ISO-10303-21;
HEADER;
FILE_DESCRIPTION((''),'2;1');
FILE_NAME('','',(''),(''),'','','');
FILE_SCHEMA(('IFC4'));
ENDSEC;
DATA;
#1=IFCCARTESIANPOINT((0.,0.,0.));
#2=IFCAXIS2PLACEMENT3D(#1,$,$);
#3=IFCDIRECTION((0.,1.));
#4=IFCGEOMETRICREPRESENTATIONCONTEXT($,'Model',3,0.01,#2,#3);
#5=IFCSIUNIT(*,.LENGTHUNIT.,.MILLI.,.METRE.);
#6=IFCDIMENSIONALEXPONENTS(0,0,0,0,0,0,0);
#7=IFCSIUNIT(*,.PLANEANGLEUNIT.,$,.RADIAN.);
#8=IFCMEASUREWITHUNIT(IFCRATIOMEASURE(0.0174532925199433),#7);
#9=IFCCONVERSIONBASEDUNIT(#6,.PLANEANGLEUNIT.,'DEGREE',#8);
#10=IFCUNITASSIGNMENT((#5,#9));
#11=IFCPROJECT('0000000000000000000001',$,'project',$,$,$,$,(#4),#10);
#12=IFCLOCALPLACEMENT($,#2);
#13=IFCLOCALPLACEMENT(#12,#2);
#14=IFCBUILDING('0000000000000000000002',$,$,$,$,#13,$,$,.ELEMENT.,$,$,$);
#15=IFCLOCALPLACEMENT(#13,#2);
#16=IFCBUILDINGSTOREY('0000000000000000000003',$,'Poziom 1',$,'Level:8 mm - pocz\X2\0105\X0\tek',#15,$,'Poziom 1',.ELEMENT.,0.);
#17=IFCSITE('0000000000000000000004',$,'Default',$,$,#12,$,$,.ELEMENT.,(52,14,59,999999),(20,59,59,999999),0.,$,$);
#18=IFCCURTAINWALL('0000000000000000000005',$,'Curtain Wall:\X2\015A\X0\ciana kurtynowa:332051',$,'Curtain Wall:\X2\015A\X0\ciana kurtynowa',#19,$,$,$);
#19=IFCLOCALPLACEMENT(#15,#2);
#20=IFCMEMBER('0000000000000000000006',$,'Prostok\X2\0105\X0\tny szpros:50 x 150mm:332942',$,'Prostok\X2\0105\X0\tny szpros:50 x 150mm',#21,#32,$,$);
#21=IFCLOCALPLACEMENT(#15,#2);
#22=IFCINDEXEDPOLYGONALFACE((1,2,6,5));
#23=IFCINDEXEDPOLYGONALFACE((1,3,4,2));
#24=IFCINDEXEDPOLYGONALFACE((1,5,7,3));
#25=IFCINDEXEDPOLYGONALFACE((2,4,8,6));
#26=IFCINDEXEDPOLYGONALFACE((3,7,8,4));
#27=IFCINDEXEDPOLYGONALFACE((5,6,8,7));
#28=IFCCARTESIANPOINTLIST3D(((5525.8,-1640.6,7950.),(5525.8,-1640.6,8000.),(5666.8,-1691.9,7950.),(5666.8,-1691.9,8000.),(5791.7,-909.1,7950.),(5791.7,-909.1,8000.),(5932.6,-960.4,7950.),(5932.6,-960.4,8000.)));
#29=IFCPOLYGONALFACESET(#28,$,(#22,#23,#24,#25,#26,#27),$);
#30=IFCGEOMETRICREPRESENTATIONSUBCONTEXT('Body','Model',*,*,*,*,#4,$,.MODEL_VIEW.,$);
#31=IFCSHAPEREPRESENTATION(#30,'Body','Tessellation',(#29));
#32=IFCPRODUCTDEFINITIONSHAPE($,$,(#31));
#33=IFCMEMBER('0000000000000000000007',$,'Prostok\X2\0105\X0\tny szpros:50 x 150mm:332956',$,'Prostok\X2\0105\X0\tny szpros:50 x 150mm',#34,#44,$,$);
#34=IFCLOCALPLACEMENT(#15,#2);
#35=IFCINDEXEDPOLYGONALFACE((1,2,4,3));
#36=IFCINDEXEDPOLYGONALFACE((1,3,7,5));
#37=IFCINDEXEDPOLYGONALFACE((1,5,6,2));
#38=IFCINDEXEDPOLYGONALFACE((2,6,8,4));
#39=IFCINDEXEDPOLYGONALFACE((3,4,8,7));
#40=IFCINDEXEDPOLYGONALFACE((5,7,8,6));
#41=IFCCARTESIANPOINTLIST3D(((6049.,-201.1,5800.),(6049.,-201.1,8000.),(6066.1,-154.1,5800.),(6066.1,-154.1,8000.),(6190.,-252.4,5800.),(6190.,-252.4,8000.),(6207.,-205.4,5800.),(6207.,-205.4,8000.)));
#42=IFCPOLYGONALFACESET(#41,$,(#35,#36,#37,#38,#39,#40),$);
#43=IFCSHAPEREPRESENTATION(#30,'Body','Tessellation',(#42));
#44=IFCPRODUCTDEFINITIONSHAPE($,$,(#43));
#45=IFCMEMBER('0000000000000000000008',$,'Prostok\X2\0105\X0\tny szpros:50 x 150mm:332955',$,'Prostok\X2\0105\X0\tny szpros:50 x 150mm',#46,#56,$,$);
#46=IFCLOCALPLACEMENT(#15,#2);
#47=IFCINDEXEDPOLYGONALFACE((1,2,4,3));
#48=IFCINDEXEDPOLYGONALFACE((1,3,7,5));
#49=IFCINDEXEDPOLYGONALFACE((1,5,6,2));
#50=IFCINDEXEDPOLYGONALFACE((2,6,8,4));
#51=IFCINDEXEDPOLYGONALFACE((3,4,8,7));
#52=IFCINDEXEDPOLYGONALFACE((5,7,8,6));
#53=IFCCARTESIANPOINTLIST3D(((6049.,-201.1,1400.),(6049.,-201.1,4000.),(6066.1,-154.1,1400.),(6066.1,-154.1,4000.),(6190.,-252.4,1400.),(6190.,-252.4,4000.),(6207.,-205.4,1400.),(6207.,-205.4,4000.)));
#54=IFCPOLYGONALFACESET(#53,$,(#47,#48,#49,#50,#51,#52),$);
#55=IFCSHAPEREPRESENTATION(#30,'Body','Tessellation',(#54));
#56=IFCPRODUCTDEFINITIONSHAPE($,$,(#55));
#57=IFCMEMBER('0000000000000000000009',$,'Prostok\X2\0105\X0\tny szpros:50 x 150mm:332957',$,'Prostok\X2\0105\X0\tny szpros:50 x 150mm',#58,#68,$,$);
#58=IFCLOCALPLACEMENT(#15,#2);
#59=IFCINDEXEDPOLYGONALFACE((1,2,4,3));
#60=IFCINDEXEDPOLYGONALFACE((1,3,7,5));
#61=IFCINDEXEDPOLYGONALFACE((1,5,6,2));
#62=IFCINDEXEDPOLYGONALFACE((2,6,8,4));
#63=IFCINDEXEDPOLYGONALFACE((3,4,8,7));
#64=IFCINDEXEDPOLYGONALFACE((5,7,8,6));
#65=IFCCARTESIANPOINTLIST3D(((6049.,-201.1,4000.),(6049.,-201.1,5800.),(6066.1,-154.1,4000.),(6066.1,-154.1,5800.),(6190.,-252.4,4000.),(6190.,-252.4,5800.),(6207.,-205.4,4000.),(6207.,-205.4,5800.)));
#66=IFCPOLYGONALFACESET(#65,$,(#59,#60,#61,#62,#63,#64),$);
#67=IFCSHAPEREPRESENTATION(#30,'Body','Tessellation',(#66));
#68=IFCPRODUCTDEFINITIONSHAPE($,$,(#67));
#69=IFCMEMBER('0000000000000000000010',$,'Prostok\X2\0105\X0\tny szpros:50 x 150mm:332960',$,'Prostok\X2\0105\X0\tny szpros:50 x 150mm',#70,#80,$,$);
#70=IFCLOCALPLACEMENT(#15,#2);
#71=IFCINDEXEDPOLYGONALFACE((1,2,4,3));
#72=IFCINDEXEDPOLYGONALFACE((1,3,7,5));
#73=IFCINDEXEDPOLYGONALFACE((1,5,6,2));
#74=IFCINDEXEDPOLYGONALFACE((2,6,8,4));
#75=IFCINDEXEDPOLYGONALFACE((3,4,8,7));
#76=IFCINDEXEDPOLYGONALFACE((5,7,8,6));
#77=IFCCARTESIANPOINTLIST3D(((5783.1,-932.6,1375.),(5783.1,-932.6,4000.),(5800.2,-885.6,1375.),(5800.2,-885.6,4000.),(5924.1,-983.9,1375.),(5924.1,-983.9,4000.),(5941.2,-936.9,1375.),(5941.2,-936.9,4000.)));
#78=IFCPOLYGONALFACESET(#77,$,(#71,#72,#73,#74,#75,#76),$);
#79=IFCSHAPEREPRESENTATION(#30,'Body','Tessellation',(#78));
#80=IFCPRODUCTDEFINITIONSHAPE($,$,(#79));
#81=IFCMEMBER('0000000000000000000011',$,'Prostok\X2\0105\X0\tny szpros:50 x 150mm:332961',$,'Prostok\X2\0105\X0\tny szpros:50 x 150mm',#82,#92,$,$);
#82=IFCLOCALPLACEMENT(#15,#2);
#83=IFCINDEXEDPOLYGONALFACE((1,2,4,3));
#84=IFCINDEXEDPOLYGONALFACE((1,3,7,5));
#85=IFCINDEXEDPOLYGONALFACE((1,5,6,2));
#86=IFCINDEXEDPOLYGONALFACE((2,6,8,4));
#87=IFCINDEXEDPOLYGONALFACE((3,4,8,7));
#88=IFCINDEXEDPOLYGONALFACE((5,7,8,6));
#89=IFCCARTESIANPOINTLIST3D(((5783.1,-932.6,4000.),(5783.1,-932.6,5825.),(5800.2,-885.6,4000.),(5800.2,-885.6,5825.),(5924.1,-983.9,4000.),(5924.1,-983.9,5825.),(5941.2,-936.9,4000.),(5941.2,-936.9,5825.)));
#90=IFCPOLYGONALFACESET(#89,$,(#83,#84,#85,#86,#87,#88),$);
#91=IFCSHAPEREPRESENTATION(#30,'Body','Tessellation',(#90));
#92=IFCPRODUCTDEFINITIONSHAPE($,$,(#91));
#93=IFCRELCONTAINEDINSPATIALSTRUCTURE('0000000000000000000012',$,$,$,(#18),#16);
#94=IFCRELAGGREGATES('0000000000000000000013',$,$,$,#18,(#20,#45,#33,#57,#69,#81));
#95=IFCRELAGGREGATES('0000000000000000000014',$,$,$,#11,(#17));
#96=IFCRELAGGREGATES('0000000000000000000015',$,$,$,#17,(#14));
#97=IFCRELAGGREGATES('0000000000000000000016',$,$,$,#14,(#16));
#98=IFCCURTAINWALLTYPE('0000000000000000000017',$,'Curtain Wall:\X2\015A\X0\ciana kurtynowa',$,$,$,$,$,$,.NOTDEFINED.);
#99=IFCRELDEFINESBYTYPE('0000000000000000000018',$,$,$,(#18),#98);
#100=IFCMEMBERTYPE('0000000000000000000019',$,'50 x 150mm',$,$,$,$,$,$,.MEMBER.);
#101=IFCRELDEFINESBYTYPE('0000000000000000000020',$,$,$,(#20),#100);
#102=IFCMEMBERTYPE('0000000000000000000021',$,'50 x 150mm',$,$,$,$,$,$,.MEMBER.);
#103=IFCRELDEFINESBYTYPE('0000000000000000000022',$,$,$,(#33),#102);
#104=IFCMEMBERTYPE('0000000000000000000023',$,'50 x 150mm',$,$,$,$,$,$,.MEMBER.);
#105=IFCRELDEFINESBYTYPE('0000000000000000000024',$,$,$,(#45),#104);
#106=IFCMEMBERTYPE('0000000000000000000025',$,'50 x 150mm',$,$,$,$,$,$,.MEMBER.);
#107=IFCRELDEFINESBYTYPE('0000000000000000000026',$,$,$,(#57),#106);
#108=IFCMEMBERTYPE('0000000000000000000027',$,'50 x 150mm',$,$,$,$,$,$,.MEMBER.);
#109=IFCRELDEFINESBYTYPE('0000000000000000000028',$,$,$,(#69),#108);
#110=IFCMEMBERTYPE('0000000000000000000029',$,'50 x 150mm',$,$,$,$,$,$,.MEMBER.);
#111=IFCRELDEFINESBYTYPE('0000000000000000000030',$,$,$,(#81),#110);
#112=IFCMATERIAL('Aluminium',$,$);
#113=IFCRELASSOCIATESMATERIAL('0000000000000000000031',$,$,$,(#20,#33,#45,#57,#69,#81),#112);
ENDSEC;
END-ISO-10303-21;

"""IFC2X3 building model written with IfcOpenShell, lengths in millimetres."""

from ifc_helpers import new_model, entity, si_unit, converted_unit, direction, frame, origin, origin_2d_with_axis, place, context, subcontext, project, spatial, rectangle, extrude, source, transform, mapped, material, type_object, type_shapes, element, aggregate, save


model = new_model("IFC2X3")

# Units and contexts
model_context = context("Model", 3, precision=0.01, world=origin(), true_north=direction((0.0, 1.0)))
body_context = subcontext(model_context, "Body", "Model", "MODEL_VIEW")
ifc_project = project(units=[si_unit("LENGTHUNIT", "METRE", prefix="MILLI"), converted_unit("PLANEANGLEUNIT", "DEGREE", entity("IfcRatioMeasure", 0.0174532925199433), si_unit("PLANEANGLEUNIT", "RADIAN"), dimensions=[0, 0, 0, 0, 0, 0, 0])], contexts=[model_context])

# Site, building, storey
site_placement = place(None, origin())
site = spatial("IfcSite", under=ifc_project, at=site_placement, Name="Default", CompositionType="ELEMENT", RefLatitude=(52, 14, 59, 999999), RefLongitude=(20, 59, 59, 999999), RefElevation=0.0)
building_placement = place(site_placement, origin())
building = spatial("IfcBuilding", under=site, at=building_placement, CompositionType="ELEMENT")
storey_placement = place(building_placement, origin())
storey = spatial("IfcBuildingStorey", under=building, at=storey_placement, Name="Poziom 1", ObjectType="Level:8 mm - początek", LongName="Poziom 1", CompositionType="ELEMENT", Elevation=0.0)

# Curtain wall, members
curtain_wall_type = type_object("IfcCurtainWallType", Name="Curtain Wall:Ściana kurtynowa", PredefinedType="NOTDEFINED")
curtain_wall_placement = place(storey_placement, origin())
curtain_wall = element("IfcCurtainWall", 1, at=curtain_wall_placement, inside=storey, type_object=curtain_wall_type, Name="Curtain Wall:Ściana kurtynowa:332051", ObjectType="Curtain Wall:Ściana kurtynowa")
ifc_material_1 = material(Name="Aluminium")
member_type_1 = type_object("IfcMemberType", Name="50 x 150mm", PredefinedType="MEMBER")
shared_shape_1 = source(origin(), body_context, "Body", "SweptSolid", [
    extrude(rectangle(XDim=150.0, YDim=50.0, at=origin_2d_with_axis()), frame((-25.0, 0.0, -778.3), z_axis=(0.0, 0.0, 1.0), x_axis=(0.0, -1.0, 0.0)), (0.0, 0.0, 1.0), 778.3),
])
type_shapes(member_type_1, [shared_shape_1])
member_1_placement = place(storey_placement, frame((5862.1, -934.8, 8000.0), z_axis=(0.341586, 0.939851, 0.0), x_axis=(0.0, 0.0, 1.0)))
member_1 = element("IfcMember", 2, at=member_1_placement, type_object=member_type_1, material=ifc_material_1, Name="Prostokątny szpros:50 x 150mm:332942", ObjectType="Prostokątny szpros:50 x 150mm", context=body_context, shape_type="MappedRepresentation", body=[
    mapped(shared_shape_1, transform((0.0, 0.0, 0.0), scale=1.0)),
])
member_type_2 = type_object("IfcMemberType", Name="50 x 150mm", PredefinedType="MEMBER")
shared_shape_2 = source(origin(), body_context, "Body", "SweptSolid", [
    extrude(rectangle(XDim=150.0, YDim=50.0, at=origin_2d_with_axis()), frame((0.0, 0.0, -2200.0), z_axis=(0.0, 0.0, 1.0), x_axis=(0.0, -1.0, 0.0)), (0.0, 0.0, 1.0), 2200.0),
])
type_shapes(member_type_2, [shared_shape_2])
member_2_placement = place(storey_placement, frame((6128.0, -203.2, 5800.0), z_axis=(0.0, 0.0, -1.0), x_axis=(0.341586, 0.939851, 0.0)))
member_2 = element("IfcMember", 3, at=member_2_placement, type_object=member_type_2, material=ifc_material_1, Name="Prostokątny szpros:50 x 150mm:332956", ObjectType="Prostokątny szpros:50 x 150mm", context=body_context, shape_type="MappedRepresentation", body=[
    mapped(shared_shape_2, transform((0.0, 0.0, 0.0), scale=1.0)),
])
member_type_3 = type_object("IfcMemberType", Name="50 x 150mm", PredefinedType="MEMBER")
shared_shape_3 = source(origin(), body_context, "Body", "SweptSolid", [
    extrude(rectangle(XDim=150.0, YDim=50.0, at=origin_2d_with_axis()), frame((0.0, 0.0, -2600.0), z_axis=(0.0, 0.0, 1.0), x_axis=(0.0, -1.0, 0.0)), (0.0, 0.0, 1.0), 2600.0),
])
type_shapes(member_type_3, [shared_shape_3])
member_3_placement = place(storey_placement, frame((6128.0, -203.2, 1400.0), z_axis=(0.0, 0.0, -1.0), x_axis=(0.341586, 0.939851, 0.0)))
member_3 = element("IfcMember", 4, at=member_3_placement, type_object=member_type_3, material=ifc_material_1, Name="Prostokątny szpros:50 x 150mm:332955", ObjectType="Prostokątny szpros:50 x 150mm", context=body_context, shape_type="MappedRepresentation", body=[
    mapped(shared_shape_3, transform((0.0, 0.0, 0.0), scale=1.0)),
])
member_type_4 = type_object("IfcMemberType", Name="50 x 150mm", PredefinedType="MEMBER")
shared_shape_4 = source(origin(), body_context, "Body", "SweptSolid", [
    extrude(rectangle(XDim=150.0, YDim=50.0, at=origin_2d_with_axis()), frame((0.0, 0.0, -1800.0), z_axis=(0.0, 0.0, 1.0), x_axis=(0.0, -1.0, 0.0)), (0.0, 0.0, 1.0), 1800.0),
])
type_shapes(member_type_4, [shared_shape_4])
member_4_placement = place(storey_placement, frame((6128.0, -203.2, 4000.0), z_axis=(0.0, 0.0, -1.0), x_axis=(0.341586, 0.939851, 0.0)))
member_4 = element("IfcMember", 5, at=member_4_placement, type_object=member_type_4, material=ifc_material_1, Name="Prostokątny szpros:50 x 150mm:332957", ObjectType="Prostokątny szpros:50 x 150mm", context=body_context, shape_type="MappedRepresentation", body=[
    mapped(shared_shape_4, transform((0.0, 0.0, 0.0), scale=1.0)),
])
member_type_5 = type_object("IfcMemberType", Name="50 x 150mm", PredefinedType="MEMBER")
shared_shape_5 = source(origin(), body_context, "Body", "SweptSolid", [
    extrude(rectangle(XDim=150.0, YDim=50.0, at=origin_2d_with_axis()), frame((0.0, 0.0, -2625.0), z_axis=(0.0, 0.0, 1.0), x_axis=(0.0, -1.0, 0.0)), (0.0, 0.0, 1.0), 2625.0),
])
type_shapes(member_type_5, [shared_shape_5])
member_5_placement = place(storey_placement, frame((5862.1, -934.8, 1375.0), z_axis=(0.0, 0.0, -1.0), x_axis=(0.341586, 0.939851, 0.0)))
member_5 = element("IfcMember", 6, at=member_5_placement, type_object=member_type_5, material=ifc_material_1, Name="Prostokątny szpros:50 x 150mm:332960", ObjectType="Prostokątny szpros:50 x 150mm", context=body_context, shape_type="MappedRepresentation", body=[
    mapped(shared_shape_5, transform((0.0, 0.0, 0.0), scale=1.0)),
])
member_type_6 = type_object("IfcMemberType", Name="50 x 150mm", PredefinedType="MEMBER")
shared_shape_6 = source(origin(), body_context, "Body", "SweptSolid", [
    extrude(rectangle(XDim=150.0, YDim=50.0, at=origin_2d_with_axis()), frame((0.0, 0.0, -1825.0), z_axis=(0.0, 0.0, 1.0), x_axis=(0.0, -1.0, 0.0)), (0.0, 0.0, 1.0), 1825.0),
])
type_shapes(member_type_6, [shared_shape_6])
member_6_placement = place(storey_placement, frame((5862.1, -934.8, 4000.0), z_axis=(0.0, 0.0, -1.0), x_axis=(0.341586, 0.939851, 0.0)))
member_6 = element("IfcMember", 7, at=member_6_placement, type_object=member_type_6, material=ifc_material_1, Name="Prostokątny szpros:50 x 150mm:332961", ObjectType="Prostokątny szpros:50 x 150mm", context=body_context, shape_type="MappedRepresentation", body=[
    mapped(shared_shape_6, transform((0.0, 0.0, 0.0), scale=1.0)),
])
aggregate(curtain_wall, [member_1, member_3, member_2, member_4, member_5, member_6])

save(model, "model.ifc")
